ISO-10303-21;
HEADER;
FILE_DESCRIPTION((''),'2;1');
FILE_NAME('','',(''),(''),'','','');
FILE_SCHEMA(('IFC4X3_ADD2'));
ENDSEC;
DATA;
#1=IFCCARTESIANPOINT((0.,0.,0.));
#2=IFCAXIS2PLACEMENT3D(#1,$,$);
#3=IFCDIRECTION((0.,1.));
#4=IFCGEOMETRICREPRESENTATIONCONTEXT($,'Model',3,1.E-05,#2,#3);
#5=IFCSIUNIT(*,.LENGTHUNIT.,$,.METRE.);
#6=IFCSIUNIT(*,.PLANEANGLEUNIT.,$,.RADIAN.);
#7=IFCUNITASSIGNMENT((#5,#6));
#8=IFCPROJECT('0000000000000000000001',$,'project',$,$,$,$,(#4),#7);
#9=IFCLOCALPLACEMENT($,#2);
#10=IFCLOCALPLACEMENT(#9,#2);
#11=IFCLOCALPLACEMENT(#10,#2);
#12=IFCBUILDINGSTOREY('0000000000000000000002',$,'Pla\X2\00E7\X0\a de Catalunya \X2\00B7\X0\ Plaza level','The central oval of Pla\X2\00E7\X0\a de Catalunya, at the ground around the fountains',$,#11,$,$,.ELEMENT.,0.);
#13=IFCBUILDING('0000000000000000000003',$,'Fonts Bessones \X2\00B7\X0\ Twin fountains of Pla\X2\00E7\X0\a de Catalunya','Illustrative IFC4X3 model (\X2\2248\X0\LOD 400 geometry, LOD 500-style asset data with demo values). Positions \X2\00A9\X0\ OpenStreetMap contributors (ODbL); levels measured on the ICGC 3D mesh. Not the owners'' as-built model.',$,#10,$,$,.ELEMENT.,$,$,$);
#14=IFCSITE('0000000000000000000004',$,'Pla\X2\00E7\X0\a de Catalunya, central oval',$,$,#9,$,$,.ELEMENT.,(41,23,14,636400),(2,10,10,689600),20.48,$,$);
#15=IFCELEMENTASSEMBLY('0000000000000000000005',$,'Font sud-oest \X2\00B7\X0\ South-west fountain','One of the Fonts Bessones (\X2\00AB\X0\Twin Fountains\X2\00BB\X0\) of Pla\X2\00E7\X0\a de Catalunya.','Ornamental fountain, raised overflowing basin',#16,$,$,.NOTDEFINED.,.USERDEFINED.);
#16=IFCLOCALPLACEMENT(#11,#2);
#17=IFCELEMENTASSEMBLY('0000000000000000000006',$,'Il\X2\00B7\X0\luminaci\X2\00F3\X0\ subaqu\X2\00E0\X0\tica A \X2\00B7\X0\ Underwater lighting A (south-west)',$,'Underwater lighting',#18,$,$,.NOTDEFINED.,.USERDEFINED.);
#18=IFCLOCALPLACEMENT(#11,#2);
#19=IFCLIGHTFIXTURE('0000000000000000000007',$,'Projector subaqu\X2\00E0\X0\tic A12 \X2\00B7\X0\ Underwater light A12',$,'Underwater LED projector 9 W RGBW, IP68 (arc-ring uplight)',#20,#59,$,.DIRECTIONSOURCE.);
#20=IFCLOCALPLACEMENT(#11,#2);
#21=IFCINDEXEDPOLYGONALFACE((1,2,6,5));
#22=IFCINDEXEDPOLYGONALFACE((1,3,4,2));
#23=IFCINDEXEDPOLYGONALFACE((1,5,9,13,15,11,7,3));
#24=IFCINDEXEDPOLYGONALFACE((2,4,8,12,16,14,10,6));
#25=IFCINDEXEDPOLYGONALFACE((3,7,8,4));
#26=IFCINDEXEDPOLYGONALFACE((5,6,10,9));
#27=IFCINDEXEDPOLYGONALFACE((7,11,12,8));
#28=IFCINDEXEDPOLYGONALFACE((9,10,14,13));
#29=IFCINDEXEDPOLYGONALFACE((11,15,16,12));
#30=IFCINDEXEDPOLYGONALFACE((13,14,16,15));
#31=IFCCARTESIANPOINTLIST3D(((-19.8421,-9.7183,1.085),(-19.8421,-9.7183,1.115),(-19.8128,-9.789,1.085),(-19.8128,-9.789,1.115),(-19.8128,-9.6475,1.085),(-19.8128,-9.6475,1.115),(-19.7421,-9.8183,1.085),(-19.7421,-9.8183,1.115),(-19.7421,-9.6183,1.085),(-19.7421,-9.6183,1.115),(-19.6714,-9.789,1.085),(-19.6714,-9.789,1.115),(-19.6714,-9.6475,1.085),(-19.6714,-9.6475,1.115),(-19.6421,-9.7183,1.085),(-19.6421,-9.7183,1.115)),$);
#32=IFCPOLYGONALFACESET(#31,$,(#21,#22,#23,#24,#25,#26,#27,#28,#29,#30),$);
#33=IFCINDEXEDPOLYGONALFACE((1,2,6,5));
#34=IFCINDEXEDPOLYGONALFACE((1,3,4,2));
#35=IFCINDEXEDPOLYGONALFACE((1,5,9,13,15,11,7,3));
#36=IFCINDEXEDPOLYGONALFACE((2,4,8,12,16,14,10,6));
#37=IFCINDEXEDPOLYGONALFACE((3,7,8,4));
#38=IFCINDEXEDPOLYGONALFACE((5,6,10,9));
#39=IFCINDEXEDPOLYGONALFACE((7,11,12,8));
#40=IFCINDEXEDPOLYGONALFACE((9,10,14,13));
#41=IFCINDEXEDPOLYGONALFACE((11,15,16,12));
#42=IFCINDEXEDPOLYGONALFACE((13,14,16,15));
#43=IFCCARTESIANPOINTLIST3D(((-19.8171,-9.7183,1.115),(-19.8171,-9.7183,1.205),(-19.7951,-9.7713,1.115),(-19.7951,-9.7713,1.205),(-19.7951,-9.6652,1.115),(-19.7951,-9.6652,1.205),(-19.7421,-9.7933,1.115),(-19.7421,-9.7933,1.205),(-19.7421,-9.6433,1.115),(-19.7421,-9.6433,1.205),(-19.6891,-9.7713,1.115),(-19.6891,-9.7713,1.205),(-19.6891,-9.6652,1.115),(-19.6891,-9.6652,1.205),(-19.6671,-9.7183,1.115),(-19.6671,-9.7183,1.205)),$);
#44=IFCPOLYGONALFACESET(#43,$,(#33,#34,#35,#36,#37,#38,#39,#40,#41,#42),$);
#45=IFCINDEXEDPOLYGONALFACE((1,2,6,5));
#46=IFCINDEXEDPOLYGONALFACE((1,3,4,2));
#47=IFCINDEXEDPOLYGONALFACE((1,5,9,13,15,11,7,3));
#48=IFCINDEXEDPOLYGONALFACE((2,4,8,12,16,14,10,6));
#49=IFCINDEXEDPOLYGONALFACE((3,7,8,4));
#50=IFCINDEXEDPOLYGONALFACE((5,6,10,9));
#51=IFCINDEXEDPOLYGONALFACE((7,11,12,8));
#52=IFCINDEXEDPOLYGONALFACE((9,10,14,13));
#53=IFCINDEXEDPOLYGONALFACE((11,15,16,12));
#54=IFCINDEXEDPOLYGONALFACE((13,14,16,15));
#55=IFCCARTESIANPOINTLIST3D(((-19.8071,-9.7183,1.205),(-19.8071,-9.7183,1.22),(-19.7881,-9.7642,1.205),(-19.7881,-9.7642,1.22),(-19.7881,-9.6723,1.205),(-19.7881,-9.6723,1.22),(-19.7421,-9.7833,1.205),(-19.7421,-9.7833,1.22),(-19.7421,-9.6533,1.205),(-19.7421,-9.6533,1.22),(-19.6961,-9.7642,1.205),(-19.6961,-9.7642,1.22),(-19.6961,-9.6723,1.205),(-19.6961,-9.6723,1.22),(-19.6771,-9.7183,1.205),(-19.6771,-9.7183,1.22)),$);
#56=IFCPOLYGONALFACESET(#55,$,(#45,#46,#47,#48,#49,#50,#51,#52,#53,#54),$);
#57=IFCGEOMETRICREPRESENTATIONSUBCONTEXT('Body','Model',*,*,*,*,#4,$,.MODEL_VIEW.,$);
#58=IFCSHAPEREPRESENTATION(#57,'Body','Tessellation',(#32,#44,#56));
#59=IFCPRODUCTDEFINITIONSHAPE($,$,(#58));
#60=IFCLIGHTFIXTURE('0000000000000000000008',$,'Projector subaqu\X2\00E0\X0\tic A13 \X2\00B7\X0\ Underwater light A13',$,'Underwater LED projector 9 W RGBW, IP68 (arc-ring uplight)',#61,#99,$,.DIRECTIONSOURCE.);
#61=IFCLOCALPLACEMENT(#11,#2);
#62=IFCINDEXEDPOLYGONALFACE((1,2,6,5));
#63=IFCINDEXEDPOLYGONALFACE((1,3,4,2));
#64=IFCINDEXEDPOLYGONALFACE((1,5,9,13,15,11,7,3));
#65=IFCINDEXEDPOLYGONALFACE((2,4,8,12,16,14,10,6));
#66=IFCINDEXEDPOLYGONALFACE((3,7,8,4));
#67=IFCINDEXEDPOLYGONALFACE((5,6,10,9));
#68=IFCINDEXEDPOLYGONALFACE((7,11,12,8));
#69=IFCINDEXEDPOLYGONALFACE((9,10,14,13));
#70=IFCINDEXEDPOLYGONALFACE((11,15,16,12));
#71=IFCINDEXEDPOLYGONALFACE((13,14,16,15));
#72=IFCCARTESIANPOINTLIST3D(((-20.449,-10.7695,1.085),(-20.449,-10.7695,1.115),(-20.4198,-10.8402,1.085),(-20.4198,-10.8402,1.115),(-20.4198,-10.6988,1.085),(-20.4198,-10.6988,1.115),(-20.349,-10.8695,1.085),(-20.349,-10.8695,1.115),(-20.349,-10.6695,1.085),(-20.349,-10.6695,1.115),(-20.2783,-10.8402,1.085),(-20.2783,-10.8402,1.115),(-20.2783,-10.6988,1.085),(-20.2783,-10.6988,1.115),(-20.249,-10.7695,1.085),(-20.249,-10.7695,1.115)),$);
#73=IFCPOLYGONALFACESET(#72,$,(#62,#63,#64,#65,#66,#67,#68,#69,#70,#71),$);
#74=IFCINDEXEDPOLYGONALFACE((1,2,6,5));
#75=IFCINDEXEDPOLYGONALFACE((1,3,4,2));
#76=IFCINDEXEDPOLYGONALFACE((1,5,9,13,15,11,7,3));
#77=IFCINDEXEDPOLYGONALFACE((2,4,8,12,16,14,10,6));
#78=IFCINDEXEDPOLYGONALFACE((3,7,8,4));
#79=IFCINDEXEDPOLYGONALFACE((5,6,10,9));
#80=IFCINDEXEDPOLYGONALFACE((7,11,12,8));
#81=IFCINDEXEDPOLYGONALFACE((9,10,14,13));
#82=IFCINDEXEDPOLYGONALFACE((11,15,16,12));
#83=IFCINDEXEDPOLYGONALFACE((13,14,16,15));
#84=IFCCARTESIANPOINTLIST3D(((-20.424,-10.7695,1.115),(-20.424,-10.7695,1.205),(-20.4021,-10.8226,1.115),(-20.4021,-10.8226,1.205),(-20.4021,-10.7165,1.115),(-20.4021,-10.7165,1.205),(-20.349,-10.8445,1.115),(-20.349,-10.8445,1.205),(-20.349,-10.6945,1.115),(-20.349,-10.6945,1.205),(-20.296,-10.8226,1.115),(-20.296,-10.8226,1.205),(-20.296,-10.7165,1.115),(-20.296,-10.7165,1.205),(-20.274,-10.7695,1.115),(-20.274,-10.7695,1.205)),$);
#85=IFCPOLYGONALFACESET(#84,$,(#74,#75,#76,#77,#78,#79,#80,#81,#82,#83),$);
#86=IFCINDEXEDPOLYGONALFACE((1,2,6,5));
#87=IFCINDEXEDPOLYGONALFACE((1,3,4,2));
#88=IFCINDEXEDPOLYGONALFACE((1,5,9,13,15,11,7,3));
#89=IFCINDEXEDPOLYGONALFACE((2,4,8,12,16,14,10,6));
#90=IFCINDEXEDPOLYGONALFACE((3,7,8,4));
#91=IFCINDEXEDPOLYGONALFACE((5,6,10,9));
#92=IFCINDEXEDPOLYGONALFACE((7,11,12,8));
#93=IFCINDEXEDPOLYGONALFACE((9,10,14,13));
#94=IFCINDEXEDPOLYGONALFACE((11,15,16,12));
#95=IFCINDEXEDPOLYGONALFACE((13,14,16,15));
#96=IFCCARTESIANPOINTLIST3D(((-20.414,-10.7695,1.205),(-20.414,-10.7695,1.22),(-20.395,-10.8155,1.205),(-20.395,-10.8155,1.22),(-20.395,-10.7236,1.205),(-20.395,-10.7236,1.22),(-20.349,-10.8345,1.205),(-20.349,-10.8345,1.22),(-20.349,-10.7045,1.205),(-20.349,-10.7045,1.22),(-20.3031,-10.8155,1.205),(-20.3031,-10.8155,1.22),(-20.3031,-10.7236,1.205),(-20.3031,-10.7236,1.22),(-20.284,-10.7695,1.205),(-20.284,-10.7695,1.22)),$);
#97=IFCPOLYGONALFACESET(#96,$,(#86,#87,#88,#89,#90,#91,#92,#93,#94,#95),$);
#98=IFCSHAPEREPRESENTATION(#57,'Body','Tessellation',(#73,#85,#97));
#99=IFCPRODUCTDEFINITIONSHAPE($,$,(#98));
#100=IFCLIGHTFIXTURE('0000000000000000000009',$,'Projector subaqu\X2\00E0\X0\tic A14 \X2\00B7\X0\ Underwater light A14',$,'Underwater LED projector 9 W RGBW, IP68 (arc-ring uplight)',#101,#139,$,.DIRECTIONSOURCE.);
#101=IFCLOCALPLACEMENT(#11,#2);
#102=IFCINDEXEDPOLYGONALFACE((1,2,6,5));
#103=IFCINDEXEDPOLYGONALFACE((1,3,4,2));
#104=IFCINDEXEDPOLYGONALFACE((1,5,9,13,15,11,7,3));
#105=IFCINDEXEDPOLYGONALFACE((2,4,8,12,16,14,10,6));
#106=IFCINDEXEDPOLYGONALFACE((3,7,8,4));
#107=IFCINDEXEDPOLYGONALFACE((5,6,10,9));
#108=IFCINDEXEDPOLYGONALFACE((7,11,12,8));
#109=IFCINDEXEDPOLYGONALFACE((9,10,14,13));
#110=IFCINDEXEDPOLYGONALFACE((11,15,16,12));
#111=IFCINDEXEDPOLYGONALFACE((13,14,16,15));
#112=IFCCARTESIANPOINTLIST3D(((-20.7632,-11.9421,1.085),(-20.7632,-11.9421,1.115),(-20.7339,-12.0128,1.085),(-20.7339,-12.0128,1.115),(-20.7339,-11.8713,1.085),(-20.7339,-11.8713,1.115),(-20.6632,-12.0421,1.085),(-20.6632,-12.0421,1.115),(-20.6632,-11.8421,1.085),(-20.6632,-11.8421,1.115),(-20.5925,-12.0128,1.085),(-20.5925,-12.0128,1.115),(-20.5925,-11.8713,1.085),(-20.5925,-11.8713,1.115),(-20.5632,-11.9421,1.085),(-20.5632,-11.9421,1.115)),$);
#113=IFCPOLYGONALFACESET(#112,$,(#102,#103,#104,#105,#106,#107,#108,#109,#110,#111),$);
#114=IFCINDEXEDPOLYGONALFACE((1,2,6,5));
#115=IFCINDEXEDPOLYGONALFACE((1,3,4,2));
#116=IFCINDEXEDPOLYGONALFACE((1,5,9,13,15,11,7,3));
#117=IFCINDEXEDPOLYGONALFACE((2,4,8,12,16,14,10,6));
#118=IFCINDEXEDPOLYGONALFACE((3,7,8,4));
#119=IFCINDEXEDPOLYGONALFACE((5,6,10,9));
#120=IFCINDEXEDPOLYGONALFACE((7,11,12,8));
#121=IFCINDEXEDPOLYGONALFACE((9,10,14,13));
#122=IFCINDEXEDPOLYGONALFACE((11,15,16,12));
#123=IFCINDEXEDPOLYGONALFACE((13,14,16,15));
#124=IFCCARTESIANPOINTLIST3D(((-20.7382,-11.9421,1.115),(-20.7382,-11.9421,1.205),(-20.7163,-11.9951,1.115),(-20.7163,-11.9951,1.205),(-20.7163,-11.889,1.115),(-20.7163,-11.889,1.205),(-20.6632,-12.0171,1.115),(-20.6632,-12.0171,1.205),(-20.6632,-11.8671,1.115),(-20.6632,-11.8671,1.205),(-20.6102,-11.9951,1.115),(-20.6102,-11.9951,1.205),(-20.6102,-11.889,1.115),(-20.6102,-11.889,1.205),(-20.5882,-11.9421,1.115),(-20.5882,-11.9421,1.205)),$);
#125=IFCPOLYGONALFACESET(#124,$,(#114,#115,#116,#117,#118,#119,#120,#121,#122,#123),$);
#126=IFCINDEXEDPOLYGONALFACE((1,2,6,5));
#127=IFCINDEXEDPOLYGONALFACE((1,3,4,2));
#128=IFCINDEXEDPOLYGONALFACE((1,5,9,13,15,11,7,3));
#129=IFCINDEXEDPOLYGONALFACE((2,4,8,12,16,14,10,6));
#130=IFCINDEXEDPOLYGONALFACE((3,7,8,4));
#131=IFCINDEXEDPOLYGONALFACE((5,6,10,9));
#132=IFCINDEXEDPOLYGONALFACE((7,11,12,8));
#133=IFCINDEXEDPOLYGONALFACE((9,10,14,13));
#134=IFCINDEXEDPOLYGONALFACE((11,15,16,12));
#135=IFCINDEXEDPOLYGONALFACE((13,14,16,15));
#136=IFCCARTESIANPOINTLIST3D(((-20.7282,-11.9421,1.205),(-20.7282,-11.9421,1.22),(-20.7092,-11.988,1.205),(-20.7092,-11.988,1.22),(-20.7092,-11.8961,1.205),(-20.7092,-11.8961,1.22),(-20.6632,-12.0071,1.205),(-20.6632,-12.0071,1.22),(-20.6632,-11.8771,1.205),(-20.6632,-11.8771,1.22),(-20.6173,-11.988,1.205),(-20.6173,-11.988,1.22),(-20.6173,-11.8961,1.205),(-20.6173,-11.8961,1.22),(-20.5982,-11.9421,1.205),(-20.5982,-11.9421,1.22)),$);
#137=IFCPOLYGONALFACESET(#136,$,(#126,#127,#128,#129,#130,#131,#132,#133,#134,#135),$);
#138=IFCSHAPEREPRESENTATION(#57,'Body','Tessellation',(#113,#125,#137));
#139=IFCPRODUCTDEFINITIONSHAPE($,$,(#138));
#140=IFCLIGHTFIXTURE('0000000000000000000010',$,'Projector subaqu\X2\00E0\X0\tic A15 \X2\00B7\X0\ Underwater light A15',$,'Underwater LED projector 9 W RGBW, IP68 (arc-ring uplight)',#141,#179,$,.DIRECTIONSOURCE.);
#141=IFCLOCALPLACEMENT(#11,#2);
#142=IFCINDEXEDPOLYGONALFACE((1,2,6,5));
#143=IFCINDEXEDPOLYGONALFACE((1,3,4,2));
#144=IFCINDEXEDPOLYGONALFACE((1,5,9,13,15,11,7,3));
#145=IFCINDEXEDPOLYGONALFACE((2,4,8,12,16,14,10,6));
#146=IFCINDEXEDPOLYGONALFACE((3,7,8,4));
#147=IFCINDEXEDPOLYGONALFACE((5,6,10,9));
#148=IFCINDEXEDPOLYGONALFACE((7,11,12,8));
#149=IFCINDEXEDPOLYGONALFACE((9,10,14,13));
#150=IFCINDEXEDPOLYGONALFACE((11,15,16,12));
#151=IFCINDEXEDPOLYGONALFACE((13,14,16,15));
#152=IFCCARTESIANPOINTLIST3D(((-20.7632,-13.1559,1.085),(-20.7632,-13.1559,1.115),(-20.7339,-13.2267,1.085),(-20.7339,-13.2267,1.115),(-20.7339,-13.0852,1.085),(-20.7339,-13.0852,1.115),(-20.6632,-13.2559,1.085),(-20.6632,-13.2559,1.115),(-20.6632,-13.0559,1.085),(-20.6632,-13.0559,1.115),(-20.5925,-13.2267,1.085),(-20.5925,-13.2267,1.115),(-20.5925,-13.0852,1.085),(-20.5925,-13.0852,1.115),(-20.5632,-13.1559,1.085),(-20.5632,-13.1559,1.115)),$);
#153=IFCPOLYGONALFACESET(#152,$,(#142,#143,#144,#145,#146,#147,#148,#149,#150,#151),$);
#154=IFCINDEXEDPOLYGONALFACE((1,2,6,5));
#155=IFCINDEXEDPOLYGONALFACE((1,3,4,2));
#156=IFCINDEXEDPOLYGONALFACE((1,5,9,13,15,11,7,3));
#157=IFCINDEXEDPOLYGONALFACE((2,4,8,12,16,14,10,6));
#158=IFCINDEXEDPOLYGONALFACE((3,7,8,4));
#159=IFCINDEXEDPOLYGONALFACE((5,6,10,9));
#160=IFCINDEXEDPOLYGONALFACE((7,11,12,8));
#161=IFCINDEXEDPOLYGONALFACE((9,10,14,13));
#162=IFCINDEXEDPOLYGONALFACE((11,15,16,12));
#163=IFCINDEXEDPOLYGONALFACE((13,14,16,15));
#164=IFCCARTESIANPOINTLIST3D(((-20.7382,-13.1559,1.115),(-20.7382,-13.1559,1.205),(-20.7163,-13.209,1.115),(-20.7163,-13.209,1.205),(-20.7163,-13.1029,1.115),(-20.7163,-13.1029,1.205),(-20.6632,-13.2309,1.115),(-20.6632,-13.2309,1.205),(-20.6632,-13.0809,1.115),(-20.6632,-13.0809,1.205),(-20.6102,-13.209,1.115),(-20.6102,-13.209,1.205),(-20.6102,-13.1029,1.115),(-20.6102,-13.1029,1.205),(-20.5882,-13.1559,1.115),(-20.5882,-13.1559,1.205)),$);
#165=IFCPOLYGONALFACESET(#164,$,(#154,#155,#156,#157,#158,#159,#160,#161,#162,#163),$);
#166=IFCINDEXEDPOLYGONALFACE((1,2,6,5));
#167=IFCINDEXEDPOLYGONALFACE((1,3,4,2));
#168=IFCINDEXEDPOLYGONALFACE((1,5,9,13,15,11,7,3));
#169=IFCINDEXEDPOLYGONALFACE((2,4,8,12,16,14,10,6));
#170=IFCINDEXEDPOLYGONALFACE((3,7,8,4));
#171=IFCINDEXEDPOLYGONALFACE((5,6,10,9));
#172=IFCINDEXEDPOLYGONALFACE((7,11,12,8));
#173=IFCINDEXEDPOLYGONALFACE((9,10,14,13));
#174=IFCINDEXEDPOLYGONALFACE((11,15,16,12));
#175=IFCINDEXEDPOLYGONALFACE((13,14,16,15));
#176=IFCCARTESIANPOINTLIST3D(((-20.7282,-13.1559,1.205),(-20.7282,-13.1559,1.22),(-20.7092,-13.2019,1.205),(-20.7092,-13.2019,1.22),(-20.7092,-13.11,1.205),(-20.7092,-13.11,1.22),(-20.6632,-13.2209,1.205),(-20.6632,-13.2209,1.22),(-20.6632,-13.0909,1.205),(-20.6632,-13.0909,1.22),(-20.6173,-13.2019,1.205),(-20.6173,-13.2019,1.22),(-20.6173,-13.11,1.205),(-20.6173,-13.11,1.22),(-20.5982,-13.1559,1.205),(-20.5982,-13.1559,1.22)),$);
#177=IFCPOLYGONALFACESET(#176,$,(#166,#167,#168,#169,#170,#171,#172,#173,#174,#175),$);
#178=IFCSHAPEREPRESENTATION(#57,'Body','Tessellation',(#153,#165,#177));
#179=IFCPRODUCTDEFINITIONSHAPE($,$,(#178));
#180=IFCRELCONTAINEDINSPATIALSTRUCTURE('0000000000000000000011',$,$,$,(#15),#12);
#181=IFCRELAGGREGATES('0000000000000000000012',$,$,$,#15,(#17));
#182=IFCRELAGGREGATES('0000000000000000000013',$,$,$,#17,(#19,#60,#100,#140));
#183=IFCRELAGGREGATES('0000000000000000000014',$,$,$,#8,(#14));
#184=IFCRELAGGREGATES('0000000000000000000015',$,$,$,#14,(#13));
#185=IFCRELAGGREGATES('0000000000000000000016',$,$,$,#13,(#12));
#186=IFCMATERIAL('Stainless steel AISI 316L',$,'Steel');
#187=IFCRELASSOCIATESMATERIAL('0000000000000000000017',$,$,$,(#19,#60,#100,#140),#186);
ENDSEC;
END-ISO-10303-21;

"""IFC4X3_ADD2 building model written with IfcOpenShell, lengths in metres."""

from ifc_helpers import new_model, si_unit, direction, frame, origin, place, context, subcontext, project, spatial, polyline, outline, extrude, material, element, aggregate, save


model = new_model("IFC4X3_ADD2")

# Units and contexts
model_context = context("Model", 3, precision=1e-05, world=origin(), true_north=direction((0.0, 1.0)))
body_context = subcontext(model_context, "Body", "Model", "MODEL_VIEW")
ifc_project = project(units=[si_unit("LENGTHUNIT", "METRE"), si_unit("PLANEANGLEUNIT", "RADIAN")], contexts=[model_context])

# Site, building, storey
site_placement = place(None, origin())
site = spatial("IfcSite", under=ifc_project, at=site_placement, Name="Plaça de Catalunya, central oval", CompositionType="ELEMENT", RefLatitude=(41, 23, 14, 636400), RefLongitude=(2, 10, 10, 689600), RefElevation=20.48)
building_placement = place(site_placement, origin())
building = spatial("IfcBuilding", under=site, at=building_placement, Name="Fonts Bessones · Twin fountains of Plaça de Catalunya", Description="Illustrative IFC4X3 model (≈LOD 400 geometry, LOD 500-style asset data with demo values). Positions © OpenStreetMap contributors (ODbL); levels measured on the ICGC 3D mesh. Not the owners' as-built model.", CompositionType="ELEMENT")
storey_placement = place(building_placement, origin())
storey = spatial("IfcBuildingStorey", under=building, at=storey_placement, Name="Plaça de Catalunya · Plaza level", Description="The central oval of Plaça de Catalunya, at the ground around the fountains", CompositionType="ELEMENT", Elevation=0.0)

# Element assemblies, light fixtures
assembly_1_placement = place(building_placement, origin())
assembly_1 = element("IfcElementAssembly", 1, at=assembly_1_placement, inside=storey, Name="Font sud-oest · South-west fountain", Description="One of the Fonts Bessones («Twin Fountains») of Plaça de Catalunya.", ObjectType="Ornamental fountain, raised overflowing basin", AssemblyPlace="NOTDEFINED", PredefinedType="USERDEFINED")
assembly_2_placement = place(building_placement, origin())
assembly_2 = element("IfcElementAssembly", 2, at=assembly_2_placement, Name="Il·luminació subaquàtica A · Underwater lighting A (south-west)", ObjectType="Underwater lighting", AssemblyPlace="NOTDEFINED", PredefinedType="USERDEFINED")
aggregate(assembly_1, [assembly_2])
ifc_material_1 = material(Name="Stainless steel AISI 316L", Category="Steel")
light_fixture_1_placement = place(building_placement, origin())
light_fixture_1 = element("IfcLightFixture", 3, at=light_fixture_1_placement, material=ifc_material_1, Name="Projector subaquàtic A12 · Underwater light A12", ObjectType="Underwater LED projector 9 W RGBW, IP68 (arc-ring uplight)", PredefinedType="DIRECTIONSOURCE", context=body_context, shape_type="SweptSolid", body=[
    extrude(outline(polyline([(-19.6421, -9.7183), (-19.6714, -9.6475), (-19.7421, -9.6183), (-19.8128, -9.6475), (-19.8421, -9.7183), (-19.8128, -9.789), (-19.7421, -9.8183), (-19.6714, -9.789), (-19.6421, -9.7183)])), frame((0.0, 0.0, 1.085)), (0.0, 0.0, 1.0), 0.03),
    extrude(outline(polyline([(-19.6671, -9.7183), (-19.6891, -9.6652), (-19.7421, -9.6433), (-19.7951, -9.6652), (-19.8171, -9.7183), (-19.7951, -9.7713), (-19.7421, -9.7933), (-19.6891, -9.7713), (-19.6671, -9.7183)])), frame((0.0, 0.0, 1.115)), (0.0, 0.0, 1.0), 0.09),
    extrude(outline(polyline([(-19.6771, -9.7183), (-19.6961, -9.6723), (-19.7421, -9.6533), (-19.7881, -9.6723), (-19.8071, -9.7183), (-19.7881, -9.7642), (-19.7421, -9.7833), (-19.6961, -9.7642), (-19.6771, -9.7183)])), frame((0.0, 0.0, 1.205)), (0.0, 0.0, 1.0), 0.015),
])
light_fixture_2_placement = place(building_placement, origin())
light_fixture_2 = element("IfcLightFixture", 4, at=light_fixture_2_placement, material=ifc_material_1, Name="Projector subaquàtic A13 · Underwater light A13", ObjectType="Underwater LED projector 9 W RGBW, IP68 (arc-ring uplight)", PredefinedType="DIRECTIONSOURCE", context=body_context, shape_type="SweptSolid", body=[
    extrude(outline(polyline([(-20.249, -10.7695), (-20.2783, -10.6988), (-20.349, -10.6695), (-20.4198, -10.6988), (-20.449, -10.7695), (-20.4198, -10.8402), (-20.349, -10.8695), (-20.2783, -10.8402), (-20.249, -10.7695)])), frame((0.0, 0.0, 1.085)), (0.0, 0.0, 1.0), 0.03),
    extrude(outline(polyline([(-20.274, -10.7695), (-20.296, -10.7165), (-20.349, -10.6945), (-20.4021, -10.7165), (-20.424, -10.7695), (-20.4021, -10.8226), (-20.349, -10.8445), (-20.296, -10.8226), (-20.274, -10.7695)])), frame((0.0, 0.0, 1.115)), (0.0, 0.0, 1.0), 0.09),
    extrude(outline(polyline([(-20.284, -10.7695), (-20.3031, -10.7236), (-20.349, -10.7045), (-20.395, -10.7236), (-20.414, -10.7695), (-20.395, -10.8155), (-20.349, -10.8345), (-20.3031, -10.8155), (-20.284, -10.7695)])), frame((0.0, 0.0, 1.205)), (0.0, 0.0, 1.0), 0.015),
])
light_fixture_3_placement = place(building_placement, origin())
light_fixture_3 = element("IfcLightFixture", 5, at=light_fixture_3_placement, material=ifc_material_1, Name="Projector subaquàtic A14 · Underwater light A14", ObjectType="Underwater LED projector 9 W RGBW, IP68 (arc-ring uplight)", PredefinedType="DIRECTIONSOURCE", context=body_context, shape_type="SweptSolid", body=[
    extrude(outline(polyline([(-20.5632, -11.9421), (-20.5925, -11.8713), (-20.6632, -11.8421), (-20.7339, -11.8713), (-20.7632, -11.9421), (-20.7339, -12.0128), (-20.6632, -12.0421), (-20.5925, -12.0128), (-20.5632, -11.9421)])), frame((0.0, 0.0, 1.085)), (0.0, 0.0, 1.0), 0.03),
    extrude(outline(polyline([(-20.5882, -11.9421), (-20.6102, -11.889), (-20.6632, -11.8671), (-20.7163, -11.889), (-20.7382, -11.9421), (-20.7163, -11.9951), (-20.6632, -12.0171), (-20.6102, -11.9951), (-20.5882, -11.9421)])), frame((0.0, 0.0, 1.115)), (0.0, 0.0, 1.0), 0.09),
    extrude(outline(polyline([(-20.5982, -11.9421), (-20.6173, -11.8961), (-20.6632, -11.8771), (-20.7092, -11.8961), (-20.7282, -11.9421), (-20.7092, -11.988), (-20.6632, -12.0071), (-20.6173, -11.988), (-20.5982, -11.9421)])), frame((0.0, 0.0, 1.205)), (0.0, 0.0, 1.0), 0.015),
])
light_fixture_4_placement = place(building_placement, origin())
light_fixture_4 = element("IfcLightFixture", 6, at=light_fixture_4_placement, material=ifc_material_1, Name="Projector subaquàtic A15 · Underwater light A15", ObjectType="Underwater LED projector 9 W RGBW, IP68 (arc-ring uplight)", PredefinedType="DIRECTIONSOURCE", context=body_context, shape_type="SweptSolid", body=[
    extrude(outline(polyline([(-20.5632, -13.1559), (-20.5925, -13.0852), (-20.6632, -13.0559), (-20.7339, -13.0852), (-20.7632, -13.1559), (-20.7339, -13.2267), (-20.6632, -13.2559), (-20.5925, -13.2267), (-20.5632, -13.1559)])), frame((0.0, 0.0, 1.085)), (0.0, 0.0, 1.0), 0.03),
    extrude(outline(polyline([(-20.5882, -13.1559), (-20.6102, -13.1029), (-20.6632, -13.0809), (-20.7163, -13.1029), (-20.7382, -13.1559), (-20.7163, -13.209), (-20.6632, -13.2309), (-20.6102, -13.209), (-20.5882, -13.1559)])), frame((0.0, 0.0, 1.115)), (0.0, 0.0, 1.0), 0.09),
    extrude(outline(polyline([(-20.5982, -13.1559), (-20.6173, -13.11), (-20.6632, -13.0909), (-20.7092, -13.11), (-20.7282, -13.1559), (-20.7092, -13.2019), (-20.6632, -13.2209), (-20.6173, -13.2019), (-20.5982, -13.1559)])), frame((0.0, 0.0, 1.205)), (0.0, 0.0, 1.0), 0.015),
])
aggregate(assembly_2, [light_fixture_1, light_fixture_2, light_fixture_3, light_fixture_4])

save(model, "model.ifc")
